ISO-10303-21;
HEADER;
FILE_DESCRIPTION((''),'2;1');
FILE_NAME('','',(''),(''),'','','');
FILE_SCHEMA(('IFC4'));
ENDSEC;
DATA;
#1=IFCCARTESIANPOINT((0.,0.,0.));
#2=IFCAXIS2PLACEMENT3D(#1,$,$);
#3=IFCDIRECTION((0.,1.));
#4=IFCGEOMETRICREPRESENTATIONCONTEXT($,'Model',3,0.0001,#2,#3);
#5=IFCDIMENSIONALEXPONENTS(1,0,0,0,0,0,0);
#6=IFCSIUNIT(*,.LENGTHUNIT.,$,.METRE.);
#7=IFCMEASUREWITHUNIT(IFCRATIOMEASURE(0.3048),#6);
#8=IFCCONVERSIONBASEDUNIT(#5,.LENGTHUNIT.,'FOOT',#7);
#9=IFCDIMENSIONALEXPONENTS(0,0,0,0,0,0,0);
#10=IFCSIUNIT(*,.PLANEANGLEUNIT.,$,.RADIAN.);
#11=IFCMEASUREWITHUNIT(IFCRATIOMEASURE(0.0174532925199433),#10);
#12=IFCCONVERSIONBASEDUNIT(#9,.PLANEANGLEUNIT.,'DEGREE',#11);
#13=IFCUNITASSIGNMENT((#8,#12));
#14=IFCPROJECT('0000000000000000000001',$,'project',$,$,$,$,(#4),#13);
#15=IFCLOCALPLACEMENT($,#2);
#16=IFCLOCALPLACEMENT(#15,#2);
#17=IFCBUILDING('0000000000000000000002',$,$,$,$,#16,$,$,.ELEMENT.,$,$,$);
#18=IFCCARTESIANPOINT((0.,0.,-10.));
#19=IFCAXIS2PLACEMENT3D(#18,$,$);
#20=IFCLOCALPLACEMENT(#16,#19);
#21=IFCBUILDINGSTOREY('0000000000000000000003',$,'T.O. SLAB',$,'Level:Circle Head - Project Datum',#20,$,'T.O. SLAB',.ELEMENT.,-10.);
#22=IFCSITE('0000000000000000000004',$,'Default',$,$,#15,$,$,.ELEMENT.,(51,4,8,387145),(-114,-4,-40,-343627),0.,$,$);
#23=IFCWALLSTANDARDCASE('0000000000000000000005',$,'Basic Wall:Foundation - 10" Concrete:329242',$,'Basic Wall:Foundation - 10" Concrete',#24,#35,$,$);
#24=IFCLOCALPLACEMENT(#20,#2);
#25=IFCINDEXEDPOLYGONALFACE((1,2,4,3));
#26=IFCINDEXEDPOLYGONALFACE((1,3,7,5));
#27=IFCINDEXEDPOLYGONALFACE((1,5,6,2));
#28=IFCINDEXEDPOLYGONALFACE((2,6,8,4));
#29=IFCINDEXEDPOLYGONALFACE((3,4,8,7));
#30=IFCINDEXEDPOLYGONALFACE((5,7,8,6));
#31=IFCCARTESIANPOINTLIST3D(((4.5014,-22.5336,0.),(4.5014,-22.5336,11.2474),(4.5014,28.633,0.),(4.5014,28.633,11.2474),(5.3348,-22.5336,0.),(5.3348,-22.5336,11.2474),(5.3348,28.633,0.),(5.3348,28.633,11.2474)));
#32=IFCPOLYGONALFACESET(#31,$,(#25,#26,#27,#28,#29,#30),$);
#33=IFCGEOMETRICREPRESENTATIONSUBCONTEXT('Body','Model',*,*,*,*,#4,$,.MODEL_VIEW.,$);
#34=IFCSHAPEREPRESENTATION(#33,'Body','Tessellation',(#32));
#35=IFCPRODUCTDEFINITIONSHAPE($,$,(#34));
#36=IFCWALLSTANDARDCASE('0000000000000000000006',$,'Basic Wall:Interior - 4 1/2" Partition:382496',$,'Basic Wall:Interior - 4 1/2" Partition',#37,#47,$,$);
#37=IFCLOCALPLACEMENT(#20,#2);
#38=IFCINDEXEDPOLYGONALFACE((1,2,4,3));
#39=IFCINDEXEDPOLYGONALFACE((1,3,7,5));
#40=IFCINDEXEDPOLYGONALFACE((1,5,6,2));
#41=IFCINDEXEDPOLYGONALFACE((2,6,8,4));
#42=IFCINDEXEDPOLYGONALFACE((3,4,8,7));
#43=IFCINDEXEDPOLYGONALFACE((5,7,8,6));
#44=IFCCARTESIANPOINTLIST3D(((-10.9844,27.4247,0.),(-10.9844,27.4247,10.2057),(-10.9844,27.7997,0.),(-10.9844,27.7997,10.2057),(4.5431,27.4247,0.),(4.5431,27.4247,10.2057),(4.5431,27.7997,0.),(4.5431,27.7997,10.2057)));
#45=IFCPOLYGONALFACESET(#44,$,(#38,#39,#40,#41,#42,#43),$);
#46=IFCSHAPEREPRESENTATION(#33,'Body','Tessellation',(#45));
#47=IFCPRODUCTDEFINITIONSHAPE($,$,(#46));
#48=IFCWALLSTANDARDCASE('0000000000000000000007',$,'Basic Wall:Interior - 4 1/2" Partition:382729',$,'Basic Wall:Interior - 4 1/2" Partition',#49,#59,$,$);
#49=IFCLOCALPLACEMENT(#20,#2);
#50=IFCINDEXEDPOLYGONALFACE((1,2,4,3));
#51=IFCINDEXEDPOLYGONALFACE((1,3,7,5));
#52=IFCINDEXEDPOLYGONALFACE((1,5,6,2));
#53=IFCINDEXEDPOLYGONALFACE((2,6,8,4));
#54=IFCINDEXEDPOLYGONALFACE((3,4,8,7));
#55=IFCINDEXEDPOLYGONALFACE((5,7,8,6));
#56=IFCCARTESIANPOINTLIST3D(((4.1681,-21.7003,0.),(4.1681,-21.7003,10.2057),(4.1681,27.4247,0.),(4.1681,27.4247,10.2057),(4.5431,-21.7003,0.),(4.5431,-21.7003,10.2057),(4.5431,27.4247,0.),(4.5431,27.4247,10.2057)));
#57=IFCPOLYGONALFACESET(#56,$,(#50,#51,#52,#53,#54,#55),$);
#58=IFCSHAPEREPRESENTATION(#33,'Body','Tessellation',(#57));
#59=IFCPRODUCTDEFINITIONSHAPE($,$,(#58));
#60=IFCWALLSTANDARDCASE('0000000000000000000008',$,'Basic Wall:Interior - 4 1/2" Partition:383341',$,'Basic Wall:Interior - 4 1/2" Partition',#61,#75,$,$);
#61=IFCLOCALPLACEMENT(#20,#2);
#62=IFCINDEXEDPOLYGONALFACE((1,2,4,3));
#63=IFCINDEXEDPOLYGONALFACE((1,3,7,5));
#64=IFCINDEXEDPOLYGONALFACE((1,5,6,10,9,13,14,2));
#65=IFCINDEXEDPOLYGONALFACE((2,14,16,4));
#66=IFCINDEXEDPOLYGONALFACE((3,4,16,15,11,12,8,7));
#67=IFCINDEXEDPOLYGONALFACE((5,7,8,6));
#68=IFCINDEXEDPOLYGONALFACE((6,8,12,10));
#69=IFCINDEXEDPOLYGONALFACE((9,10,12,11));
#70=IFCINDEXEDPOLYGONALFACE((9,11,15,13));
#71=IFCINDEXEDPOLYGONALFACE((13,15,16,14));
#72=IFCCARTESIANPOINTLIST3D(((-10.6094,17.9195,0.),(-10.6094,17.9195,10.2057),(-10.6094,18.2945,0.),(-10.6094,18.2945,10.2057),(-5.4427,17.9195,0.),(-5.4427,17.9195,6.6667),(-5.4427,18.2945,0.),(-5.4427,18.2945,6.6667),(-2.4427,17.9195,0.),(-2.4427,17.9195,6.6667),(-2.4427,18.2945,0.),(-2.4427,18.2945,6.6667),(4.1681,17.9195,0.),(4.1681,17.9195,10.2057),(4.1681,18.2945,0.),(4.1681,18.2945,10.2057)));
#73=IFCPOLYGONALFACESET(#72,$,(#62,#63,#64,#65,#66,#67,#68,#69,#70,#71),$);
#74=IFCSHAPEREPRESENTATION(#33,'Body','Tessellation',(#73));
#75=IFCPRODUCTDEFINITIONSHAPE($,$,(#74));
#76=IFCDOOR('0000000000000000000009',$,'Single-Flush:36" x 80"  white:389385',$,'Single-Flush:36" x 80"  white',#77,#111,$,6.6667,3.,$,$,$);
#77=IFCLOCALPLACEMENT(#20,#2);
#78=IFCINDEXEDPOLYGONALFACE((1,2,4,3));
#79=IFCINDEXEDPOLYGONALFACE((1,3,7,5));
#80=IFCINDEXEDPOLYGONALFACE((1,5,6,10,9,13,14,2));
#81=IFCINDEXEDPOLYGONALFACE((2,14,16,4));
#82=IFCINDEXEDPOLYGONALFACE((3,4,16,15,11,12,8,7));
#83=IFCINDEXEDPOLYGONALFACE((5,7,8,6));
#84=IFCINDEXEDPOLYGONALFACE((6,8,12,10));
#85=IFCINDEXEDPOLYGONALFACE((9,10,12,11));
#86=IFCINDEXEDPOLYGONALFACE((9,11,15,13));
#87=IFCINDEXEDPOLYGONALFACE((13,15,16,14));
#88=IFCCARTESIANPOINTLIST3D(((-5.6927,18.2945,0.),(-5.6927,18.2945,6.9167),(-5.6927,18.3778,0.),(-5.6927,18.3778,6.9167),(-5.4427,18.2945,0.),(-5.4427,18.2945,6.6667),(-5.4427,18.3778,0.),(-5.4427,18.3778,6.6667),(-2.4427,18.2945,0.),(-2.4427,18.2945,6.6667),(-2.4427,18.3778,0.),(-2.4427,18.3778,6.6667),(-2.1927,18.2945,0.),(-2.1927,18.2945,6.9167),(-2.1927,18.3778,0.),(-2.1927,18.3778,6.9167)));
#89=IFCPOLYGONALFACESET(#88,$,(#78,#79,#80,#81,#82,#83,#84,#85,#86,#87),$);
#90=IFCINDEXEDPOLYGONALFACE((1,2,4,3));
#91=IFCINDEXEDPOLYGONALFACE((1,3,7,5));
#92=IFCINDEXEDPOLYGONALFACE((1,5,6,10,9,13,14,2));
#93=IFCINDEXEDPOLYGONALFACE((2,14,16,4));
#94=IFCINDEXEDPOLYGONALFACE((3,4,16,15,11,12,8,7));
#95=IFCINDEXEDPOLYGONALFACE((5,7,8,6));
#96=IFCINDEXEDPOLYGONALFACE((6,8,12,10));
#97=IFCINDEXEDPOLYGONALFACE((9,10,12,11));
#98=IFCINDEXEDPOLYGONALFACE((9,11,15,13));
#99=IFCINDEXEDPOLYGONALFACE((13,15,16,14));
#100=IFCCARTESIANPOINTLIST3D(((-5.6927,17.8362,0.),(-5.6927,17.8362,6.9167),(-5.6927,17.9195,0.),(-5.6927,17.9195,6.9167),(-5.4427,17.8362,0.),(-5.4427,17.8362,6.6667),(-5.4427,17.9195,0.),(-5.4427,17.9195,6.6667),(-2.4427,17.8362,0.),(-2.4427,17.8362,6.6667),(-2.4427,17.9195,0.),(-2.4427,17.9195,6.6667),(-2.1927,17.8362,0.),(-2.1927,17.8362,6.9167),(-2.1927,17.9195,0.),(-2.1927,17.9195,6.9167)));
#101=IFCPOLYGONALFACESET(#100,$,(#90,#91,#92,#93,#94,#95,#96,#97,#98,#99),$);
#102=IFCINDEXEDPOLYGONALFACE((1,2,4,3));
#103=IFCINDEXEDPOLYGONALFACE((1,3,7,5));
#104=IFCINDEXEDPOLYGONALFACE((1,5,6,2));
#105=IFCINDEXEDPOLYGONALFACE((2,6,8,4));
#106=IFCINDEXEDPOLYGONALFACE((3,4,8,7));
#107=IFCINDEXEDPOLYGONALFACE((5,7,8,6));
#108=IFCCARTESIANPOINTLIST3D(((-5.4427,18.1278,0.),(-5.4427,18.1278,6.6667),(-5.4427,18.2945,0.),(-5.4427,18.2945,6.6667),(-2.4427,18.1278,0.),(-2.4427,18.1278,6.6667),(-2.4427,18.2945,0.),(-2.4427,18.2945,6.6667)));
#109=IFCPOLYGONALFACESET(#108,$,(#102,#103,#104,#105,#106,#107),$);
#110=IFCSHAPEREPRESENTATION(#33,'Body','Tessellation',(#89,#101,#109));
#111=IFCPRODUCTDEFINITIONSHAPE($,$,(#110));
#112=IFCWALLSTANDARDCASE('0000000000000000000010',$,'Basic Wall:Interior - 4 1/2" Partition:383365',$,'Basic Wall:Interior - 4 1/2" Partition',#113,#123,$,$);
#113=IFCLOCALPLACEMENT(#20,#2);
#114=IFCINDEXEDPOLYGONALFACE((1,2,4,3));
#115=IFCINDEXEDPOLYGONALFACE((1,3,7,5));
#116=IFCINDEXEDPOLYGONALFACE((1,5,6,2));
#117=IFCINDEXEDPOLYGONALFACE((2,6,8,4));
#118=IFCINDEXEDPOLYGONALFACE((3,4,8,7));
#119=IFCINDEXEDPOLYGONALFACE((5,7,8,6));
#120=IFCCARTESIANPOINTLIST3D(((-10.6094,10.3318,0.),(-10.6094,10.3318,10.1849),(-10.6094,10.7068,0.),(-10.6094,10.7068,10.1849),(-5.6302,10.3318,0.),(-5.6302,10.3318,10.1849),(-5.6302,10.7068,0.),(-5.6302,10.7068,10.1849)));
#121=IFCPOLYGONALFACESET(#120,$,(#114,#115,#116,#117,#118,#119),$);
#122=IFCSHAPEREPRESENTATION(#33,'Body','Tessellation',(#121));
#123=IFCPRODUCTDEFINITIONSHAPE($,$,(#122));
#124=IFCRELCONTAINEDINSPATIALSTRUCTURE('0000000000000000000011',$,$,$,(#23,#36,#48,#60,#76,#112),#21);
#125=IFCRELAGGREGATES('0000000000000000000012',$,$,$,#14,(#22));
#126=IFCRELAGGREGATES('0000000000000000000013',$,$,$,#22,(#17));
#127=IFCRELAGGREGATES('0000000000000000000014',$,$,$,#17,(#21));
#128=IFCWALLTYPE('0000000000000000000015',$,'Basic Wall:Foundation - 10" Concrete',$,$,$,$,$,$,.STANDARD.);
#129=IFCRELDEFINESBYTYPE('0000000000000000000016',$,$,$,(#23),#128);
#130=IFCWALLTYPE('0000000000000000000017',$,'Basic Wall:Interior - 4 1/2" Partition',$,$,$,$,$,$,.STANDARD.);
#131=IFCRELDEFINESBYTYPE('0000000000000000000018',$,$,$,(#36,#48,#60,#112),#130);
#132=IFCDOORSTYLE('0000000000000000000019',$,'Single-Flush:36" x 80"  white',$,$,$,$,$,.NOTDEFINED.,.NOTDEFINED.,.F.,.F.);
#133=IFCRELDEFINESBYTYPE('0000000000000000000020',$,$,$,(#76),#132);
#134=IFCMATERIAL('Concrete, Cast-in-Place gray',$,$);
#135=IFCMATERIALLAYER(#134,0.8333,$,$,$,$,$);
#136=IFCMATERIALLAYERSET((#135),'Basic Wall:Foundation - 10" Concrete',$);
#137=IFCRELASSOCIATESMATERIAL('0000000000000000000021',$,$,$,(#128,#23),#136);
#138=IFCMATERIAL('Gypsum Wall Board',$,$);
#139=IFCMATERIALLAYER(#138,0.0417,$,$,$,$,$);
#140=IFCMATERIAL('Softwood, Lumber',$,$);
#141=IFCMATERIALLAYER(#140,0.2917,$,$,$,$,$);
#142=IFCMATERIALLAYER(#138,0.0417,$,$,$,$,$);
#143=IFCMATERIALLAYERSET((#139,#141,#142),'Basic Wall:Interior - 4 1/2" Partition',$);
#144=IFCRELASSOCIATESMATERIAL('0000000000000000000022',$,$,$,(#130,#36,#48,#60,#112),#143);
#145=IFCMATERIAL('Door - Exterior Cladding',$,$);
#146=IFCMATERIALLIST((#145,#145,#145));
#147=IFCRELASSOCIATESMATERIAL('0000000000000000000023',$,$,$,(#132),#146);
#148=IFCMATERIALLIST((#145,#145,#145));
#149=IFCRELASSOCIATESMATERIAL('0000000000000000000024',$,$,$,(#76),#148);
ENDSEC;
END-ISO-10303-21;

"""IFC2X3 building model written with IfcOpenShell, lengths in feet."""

from ifc_helpers import new_model, entity, si_unit, converted_unit, direction, frame, frame_2d, origin, origin_2d_with_axis, place, context, subcontext, project, spatial, polyline, rectangle, outline, extrude, source, transform, mapped, material, material_list, layer, layer_set, layer_usage, type_object, type_shapes, element, fill, save


model = new_model("IFC2X3")

# Units and contexts
model_context = context("Model", 3, precision=0.0001, world=origin(), true_north=direction((0.0, 1.0)))
body_context = subcontext(model_context, "Body", "Model", "MODEL_VIEW")
ifc_project = project(units=[converted_unit("LENGTHUNIT", "FOOT", entity("IfcRatioMeasure", 0.3048), si_unit("LENGTHUNIT", "METRE"), dimensions=[1, 0, 0, 0, 0, 0, 0]), converted_unit("PLANEANGLEUNIT", "DEGREE", entity("IfcRatioMeasure", 0.0174532925199433), si_unit("PLANEANGLEUNIT", "RADIAN"), dimensions=[0, 0, 0, 0, 0, 0, 0])], contexts=[model_context])

# Site, building, storey
site_placement = place(None, origin())
site = spatial("IfcSite", under=ifc_project, at=site_placement, Name="Default", CompositionType="ELEMENT", RefLatitude=(51, 4, 8, 387145), RefLongitude=(-114, -4, -40, -343627), RefElevation=0.0)
building_placement = place(site_placement, origin())
building = spatial("IfcBuilding", under=site, at=building_placement, CompositionType="ELEMENT")
storey_placement = place(building_placement, frame((0.0, 0.0, -10.0)))
storey = spatial("IfcBuildingStorey", under=building, at=storey_placement, Name="T.O. SLAB", ObjectType="Level:Circle Head - Project Datum", LongName="T.O. SLAB", CompositionType="ELEMENT", Elevation=-10.0)

# Wall
ifc_material_1 = material(Name="Concrete, Cast-in-Place gray")
ifc_layer_1 = layer(ifc_material_1, 0.8333)
ifc_layer_set_1 = layer_set([ifc_layer_1], Name="Basic Wall:Foundation - 10\" Concrete")
ifc_layer_usage_1 = layer_usage(ifc_layer_set_1, "AXIS2", "NEGATIVE", 0.4167)
wall_type_1 = type_object("IfcWallType", Name="Basic Wall:Foundation - 10\" Concrete", PredefinedType="STANDARD", material=ifc_layer_set_1)
wall_1_placement = place(storey_placement, frame((4.9181, 28.633, 0.0), z_axis=(0.0, 0.0, 1.0), x_axis=(0.0, -1.0, 0.0)))
element("IfcWallStandardCase", 1, at=wall_1_placement, inside=storey, type_object=wall_type_1, material=ifc_layer_usage_1, Name="Basic Wall:Foundation - 10\" Concrete:329242", ObjectType="Basic Wall:Foundation - 10\" Concrete", context=body_context, shape_type="SweptSolid", body=[
    extrude(rectangle(XDim=51.1667, YDim=0.8333, at=frame_2d((25.5833, 0.0), x_axis=(-1.0, 0.0))), origin(), (0.0, 0.0, 1.0), 11.2474),
])

# Walls
ifc_material_2 = material(Name="Gypsum Wall Board")
ifc_layer_2 = layer(ifc_material_2, 0.0417)
ifc_material_3 = material(Name="Softwood, Lumber")
ifc_layer_3 = layer(ifc_material_3, 0.2917)
ifc_layer_4 = layer(ifc_material_2, 0.0417)
ifc_layer_set_2 = layer_set([ifc_layer_2, ifc_layer_3, ifc_layer_4], Name="Basic Wall:Interior - 4 1/2\" Partition")
ifc_layer_usage_2 = layer_usage(ifc_layer_set_2, "AXIS2", "NEGATIVE", 0.1875)
wall_type_2 = type_object("IfcWallType", Name="Basic Wall:Interior - 4 1/2\" Partition", PredefinedType="STANDARD", material=ifc_layer_set_2)
wall_2_placement = place(storey_placement, frame((-10.9844, 27.6122, 0.0)))
element("IfcWallStandardCase", 2, at=wall_2_placement, inside=storey, type_object=wall_type_2, material=ifc_layer_usage_2, Name="Basic Wall:Interior - 4 1/2\" Partition:382496", ObjectType="Basic Wall:Interior - 4 1/2\" Partition", context=body_context, shape_type="SweptSolid", body=[
    extrude(rectangle(XDim=15.5275, YDim=0.375, at=frame_2d((7.7637, 0.0), x_axis=(-1.0, 0.0))), origin(), (0.0, 0.0, 1.0), 10.2057),
])
ifc_layer_usage_3 = layer_usage(ifc_layer_set_2, "AXIS2", "NEGATIVE", 0.1875)
wall_3_placement = place(storey_placement, frame((4.3556, 27.4247, 0.0), z_axis=(0.0, 0.0, 1.0), x_axis=(0.0, -1.0, 0.0)))
element("IfcWallStandardCase", 3, at=wall_3_placement, inside=storey, type_object=wall_type_2, material=ifc_layer_usage_3, Name="Basic Wall:Interior - 4 1/2\" Partition:382729", ObjectType="Basic Wall:Interior - 4 1/2\" Partition", context=body_context, shape_type="SweptSolid", body=[
    extrude(rectangle(XDim=49.125, YDim=0.375, at=frame_2d((24.5625, 0.0), x_axis=(-1.0, 0.0))), origin(), (0.0, 0.0, 1.0), 10.2057),
])

# Wall, opening, door
ifc_layer_usage_4 = layer_usage(ifc_layer_set_2, "AXIS2", "NEGATIVE", 0.1875)
wall_4_placement = place(storey_placement, frame((-10.6094, 18.107, 0.0)))
wall_4 = element("IfcWallStandardCase", 4, at=wall_4_placement, inside=storey, type_object=wall_type_2, material=ifc_layer_usage_4, Name="Basic Wall:Interior - 4 1/2\" Partition:383341", ObjectType="Basic Wall:Interior - 4 1/2\" Partition", context=body_context, shape_type="SweptSolid", body=[
    extrude(rectangle(XDim=14.7775, YDim=0.375, at=frame_2d((7.3887, 0.0), x_axis=(-1.0, 0.0))), origin(), (0.0, 0.0, 1.0), 10.2057),
])
opening_1_placement = place(wall_4_placement, frame((5.1667, -0.1875, 0.0)))
opening_1 = element("IfcOpeningElement", 5, at=opening_1_placement, cuts=wall_4, ObjectType="Opening", context=body_context, shape_type="SweptSolid", body=[
    extrude(rectangle(XDim=3.0, YDim=6.6667, at=frame_2d((3.3333, 1.5), x_axis=(0.0, -1.0))), frame((0.0, 0.0, 0.0), z_axis=(0.0, 1.0, 0.0), x_axis=(0.0, 0.0, 1.0)), (0.0, 0.0, 1.0), 0.375),
])
ifc_material_4 = material(Name="Door - Exterior Cladding")
ifc_material_list_1 = material_list([ifc_material_4, ifc_material_4, ifc_material_4])
ifc_material_list_2 = material_list([ifc_material_4, ifc_material_4, ifc_material_4])
door_style_1 = type_object("IfcDoorStyle", Name="Single-Flush:36\" x 80\"  white", ConstructionType="NOTDEFINED", OperationType="NOTDEFINED", ParameterTakesPrecedence=False, Sizeable=False, material=ifc_material_list_2)
shared_shape_1 = source(origin(), body_context, "Body", "SweptSolid", [
    extrude(outline(polyline([(-1.75, -3.5208), (1.75, -3.5208), (1.75, 3.3958), (1.5, 3.3958), (1.5, -3.2708), (-1.5, -3.2708), (-1.5, 3.3958), (-1.75, 3.3958), (-1.75, -3.5208)])), frame((1.5, 0.4583, 3.3958), z_axis=(0.0, -1.0, 0.0), x_axis=(-1.0, 0.0, 0.0)), (0.0, 0.0, 1.0), 0.0833),
    extrude(outline(polyline([(-3.5208, -1.75), (3.3958, -1.75), (3.3958, -1.5), (-3.2708, -1.5), (-3.2708, 1.5), (3.3958, 1.5), (3.3958, 1.75), (-3.5208, 1.75), (-3.5208, -1.75)])), frame((1.5, 0.0, 3.3958), z_axis=(0.0, -1.0, 0.0), x_axis=(0.0, 0.0, -1.0)), (0.0, 0.0, 1.0), 0.0833),
    extrude(rectangle(XDim=3.0, YDim=0.1667, at=origin_2d_with_axis()), frame((1.5, 0.2917, 0.0)), (0.0, 0.0, 1.0), 6.6667),
])
type_shapes(door_style_1, [shared_shape_1])
door_1_placement = place(opening_1_placement, origin())
door_1 = element("IfcDoor", 6, at=door_1_placement, inside=storey, type_object=door_style_1, material=ifc_material_list_1, Name="Single-Flush:36\" x 80\"  white:389385", ObjectType="Single-Flush:36\" x 80\"  white", OverallHeight=6.6667, OverallWidth=3.0, context=body_context, shape_type="MappedRepresentation", body=[
    mapped(shared_shape_1, transform((0.0, 0.0, 0.0), scale=1.0)),
])
fill(opening_1, door_1)

# Wall
ifc_layer_usage_5 = layer_usage(ifc_layer_set_2, "AXIS2", "NEGATIVE", 0.1875)
wall_5_placement = place(storey_placement, frame((-5.6302, 10.5193, 0.0), z_axis=(0.0, 0.0, 1.0), x_axis=(-1.0, 0.0, 0.0)))
element("IfcWallStandardCase", 7, at=wall_5_placement, inside=storey, type_object=wall_type_2, material=ifc_layer_usage_5, Name="Basic Wall:Interior - 4 1/2\" Partition:383365", ObjectType="Basic Wall:Interior - 4 1/2\" Partition", context=body_context, shape_type="SweptSolid", body=[
    extrude(rectangle(XDim=4.9792, YDim=0.375, at=frame_2d((2.4896, 0.0), x_axis=(-1.0, 0.0))), origin(), (0.0, 0.0, 1.0), 10.1849),
])

save(model, "model.ifc")
